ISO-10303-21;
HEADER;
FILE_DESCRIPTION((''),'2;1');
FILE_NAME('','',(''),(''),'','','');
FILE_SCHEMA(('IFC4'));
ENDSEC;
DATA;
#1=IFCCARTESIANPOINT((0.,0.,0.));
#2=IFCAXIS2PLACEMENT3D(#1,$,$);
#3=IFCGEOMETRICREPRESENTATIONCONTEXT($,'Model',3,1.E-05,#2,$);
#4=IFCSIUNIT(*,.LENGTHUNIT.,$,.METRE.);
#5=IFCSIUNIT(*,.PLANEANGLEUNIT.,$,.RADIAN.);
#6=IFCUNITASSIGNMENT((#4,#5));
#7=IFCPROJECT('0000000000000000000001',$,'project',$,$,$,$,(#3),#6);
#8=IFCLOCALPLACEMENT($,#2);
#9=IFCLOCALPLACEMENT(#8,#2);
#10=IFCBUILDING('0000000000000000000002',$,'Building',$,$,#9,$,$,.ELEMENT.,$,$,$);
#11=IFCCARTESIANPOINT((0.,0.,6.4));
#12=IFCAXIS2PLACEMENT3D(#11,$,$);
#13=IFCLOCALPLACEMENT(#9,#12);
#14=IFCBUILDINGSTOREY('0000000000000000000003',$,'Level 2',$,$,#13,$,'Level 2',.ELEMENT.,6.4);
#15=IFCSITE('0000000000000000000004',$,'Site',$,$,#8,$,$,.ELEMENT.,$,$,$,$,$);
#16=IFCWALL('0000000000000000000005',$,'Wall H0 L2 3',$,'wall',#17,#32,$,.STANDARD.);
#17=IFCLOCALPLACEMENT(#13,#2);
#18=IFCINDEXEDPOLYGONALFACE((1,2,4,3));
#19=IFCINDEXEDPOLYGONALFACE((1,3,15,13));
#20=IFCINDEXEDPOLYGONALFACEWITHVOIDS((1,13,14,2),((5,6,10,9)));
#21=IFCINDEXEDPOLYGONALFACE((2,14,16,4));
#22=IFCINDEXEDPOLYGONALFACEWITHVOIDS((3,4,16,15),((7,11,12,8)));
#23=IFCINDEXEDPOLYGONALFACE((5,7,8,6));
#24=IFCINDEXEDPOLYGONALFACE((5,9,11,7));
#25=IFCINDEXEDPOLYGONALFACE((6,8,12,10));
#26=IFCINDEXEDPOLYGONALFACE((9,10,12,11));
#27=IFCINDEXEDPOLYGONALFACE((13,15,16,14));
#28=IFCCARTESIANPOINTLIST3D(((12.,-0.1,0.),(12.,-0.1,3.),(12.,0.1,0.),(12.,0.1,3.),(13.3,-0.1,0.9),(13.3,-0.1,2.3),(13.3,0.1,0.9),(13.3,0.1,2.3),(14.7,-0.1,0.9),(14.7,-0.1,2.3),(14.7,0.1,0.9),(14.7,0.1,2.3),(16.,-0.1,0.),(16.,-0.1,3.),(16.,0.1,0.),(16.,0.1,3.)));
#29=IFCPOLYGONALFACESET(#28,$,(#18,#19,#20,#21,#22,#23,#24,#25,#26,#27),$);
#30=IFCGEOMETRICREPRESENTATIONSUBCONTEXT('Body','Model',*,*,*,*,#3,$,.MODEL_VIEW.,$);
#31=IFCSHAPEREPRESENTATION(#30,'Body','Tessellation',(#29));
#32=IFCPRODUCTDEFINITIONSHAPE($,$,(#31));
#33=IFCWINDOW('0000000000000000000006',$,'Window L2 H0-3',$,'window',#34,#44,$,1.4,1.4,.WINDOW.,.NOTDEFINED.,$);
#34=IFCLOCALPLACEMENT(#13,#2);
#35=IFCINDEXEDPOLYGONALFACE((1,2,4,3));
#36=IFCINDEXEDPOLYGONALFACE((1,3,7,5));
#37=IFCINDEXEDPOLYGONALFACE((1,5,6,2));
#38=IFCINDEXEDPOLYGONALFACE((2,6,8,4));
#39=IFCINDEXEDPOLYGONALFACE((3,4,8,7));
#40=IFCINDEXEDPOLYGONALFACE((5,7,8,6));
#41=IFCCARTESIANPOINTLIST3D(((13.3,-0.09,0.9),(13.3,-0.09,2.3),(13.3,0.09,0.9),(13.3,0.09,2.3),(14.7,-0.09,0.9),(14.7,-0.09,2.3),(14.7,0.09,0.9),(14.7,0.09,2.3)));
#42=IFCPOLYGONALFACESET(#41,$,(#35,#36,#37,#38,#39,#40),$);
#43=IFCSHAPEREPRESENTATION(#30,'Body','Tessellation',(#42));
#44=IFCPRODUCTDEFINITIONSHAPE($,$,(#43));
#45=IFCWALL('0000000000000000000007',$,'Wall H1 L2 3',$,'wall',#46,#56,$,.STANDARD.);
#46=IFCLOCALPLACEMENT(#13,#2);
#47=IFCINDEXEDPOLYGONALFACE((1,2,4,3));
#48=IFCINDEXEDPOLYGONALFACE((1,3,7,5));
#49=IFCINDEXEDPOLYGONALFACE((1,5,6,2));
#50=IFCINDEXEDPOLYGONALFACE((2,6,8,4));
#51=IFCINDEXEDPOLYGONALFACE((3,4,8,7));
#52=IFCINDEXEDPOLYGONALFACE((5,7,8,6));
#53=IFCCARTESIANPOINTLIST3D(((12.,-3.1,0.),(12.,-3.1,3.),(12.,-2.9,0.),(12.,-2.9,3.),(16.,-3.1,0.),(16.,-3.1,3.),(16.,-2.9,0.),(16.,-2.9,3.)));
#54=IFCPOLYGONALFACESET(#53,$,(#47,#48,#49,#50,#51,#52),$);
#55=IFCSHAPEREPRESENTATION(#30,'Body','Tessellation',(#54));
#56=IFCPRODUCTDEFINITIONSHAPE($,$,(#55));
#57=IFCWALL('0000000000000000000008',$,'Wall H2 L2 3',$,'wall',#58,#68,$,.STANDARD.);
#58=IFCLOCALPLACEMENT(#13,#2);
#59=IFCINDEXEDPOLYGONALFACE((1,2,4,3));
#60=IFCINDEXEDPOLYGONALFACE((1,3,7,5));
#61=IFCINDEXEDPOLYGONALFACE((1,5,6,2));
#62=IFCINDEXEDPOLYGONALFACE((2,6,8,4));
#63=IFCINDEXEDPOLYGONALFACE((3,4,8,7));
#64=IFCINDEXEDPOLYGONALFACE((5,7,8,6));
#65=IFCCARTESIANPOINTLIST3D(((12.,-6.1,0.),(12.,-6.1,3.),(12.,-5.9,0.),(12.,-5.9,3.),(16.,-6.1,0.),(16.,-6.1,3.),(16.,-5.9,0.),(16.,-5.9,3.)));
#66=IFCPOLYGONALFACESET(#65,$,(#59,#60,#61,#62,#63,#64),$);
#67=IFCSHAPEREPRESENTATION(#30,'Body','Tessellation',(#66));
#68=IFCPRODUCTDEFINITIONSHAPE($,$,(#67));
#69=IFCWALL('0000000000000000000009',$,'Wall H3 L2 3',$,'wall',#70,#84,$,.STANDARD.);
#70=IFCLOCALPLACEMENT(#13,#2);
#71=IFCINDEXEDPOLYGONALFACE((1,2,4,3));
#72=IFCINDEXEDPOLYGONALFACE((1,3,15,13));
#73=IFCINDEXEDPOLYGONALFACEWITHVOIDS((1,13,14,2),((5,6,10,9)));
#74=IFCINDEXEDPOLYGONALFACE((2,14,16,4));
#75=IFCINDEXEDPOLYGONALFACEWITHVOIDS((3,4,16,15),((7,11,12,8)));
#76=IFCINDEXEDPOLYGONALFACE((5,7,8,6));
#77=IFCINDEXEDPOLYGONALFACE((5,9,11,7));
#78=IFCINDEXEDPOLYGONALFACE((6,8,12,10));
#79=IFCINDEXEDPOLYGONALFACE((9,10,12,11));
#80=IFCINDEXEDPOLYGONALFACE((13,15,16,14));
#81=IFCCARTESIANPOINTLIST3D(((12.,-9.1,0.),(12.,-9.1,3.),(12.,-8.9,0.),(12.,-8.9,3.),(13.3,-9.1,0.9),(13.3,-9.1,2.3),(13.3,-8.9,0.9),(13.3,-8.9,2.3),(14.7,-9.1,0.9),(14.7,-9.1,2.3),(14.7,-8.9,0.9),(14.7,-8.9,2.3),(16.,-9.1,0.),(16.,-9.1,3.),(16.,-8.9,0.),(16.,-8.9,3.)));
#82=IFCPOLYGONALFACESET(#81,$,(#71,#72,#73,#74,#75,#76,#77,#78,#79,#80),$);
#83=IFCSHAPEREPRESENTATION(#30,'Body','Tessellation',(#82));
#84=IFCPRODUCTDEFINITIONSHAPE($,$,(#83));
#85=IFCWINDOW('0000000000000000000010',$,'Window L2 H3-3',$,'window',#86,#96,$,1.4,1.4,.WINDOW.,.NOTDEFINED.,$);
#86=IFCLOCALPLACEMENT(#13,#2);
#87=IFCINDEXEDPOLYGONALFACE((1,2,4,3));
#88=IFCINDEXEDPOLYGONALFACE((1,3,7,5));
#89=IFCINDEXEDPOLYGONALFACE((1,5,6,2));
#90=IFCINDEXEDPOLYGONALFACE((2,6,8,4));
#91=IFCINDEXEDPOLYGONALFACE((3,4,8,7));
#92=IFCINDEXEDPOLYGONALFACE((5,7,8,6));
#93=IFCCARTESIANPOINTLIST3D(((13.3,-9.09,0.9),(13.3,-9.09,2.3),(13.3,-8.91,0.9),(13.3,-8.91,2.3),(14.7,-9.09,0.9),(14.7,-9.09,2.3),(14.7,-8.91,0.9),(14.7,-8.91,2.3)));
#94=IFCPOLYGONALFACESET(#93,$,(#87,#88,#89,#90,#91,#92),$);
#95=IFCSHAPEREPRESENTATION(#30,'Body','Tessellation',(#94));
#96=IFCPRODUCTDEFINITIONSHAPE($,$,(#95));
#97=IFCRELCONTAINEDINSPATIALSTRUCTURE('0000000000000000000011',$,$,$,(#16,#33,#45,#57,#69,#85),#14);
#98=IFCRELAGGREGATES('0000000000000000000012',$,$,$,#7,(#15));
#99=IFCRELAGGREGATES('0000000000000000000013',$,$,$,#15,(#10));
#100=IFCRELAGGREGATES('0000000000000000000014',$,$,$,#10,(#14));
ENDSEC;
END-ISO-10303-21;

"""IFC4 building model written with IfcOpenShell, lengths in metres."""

from ifc_helpers import new_model, si_unit, frame, frame_2d, origin, origin_2d, place, context, subcontext, project, spatial, rectangle, extrude, element, fill, save


model = new_model("IFC4")

# Units and contexts
model_context = context("Model", 3, precision=1e-05, world=origin())
body_context = subcontext(model_context, "Body", "Model", "MODEL_VIEW")
ifc_project = project(units=[si_unit("LENGTHUNIT", "METRE"), si_unit("PLANEANGLEUNIT", "RADIAN")], contexts=[model_context])

# Site, building, storey
site_placement = place(None, origin())
site = spatial("IfcSite", under=ifc_project, at=site_placement, Name="Site", CompositionType="ELEMENT")
building_placement = place(site_placement, origin())
building = spatial("IfcBuilding", under=site, at=building_placement, Name="Building", CompositionType="ELEMENT")
storey_placement = place(building_placement, frame((0.0, 0.0, 6.4)))
storey = spatial("IfcBuildingStorey", under=building, at=storey_placement, Name="Level 2", LongName="Level 2", CompositionType="ELEMENT", Elevation=6.4)

# Wall, opening, window
wall_1_placement = place(storey_placement, frame((12.0, 0.0, 0.0), z_axis=(0.0, 0.0, 1.0), x_axis=(1.0, 0.0, 0.0)))
wall_1 = element("IfcWall", 1, at=wall_1_placement, inside=storey, Name="Wall H0 L2 3", ObjectType="wall", PredefinedType="STANDARD", context=body_context, shape_type="SweptSolid", body=[
    extrude(rectangle(XDim=4.0, YDim=0.2, at=frame_2d((2.0, 0.0))), origin(), (0.0, 0.0, 1.0), 3.0),
])
opening_1_placement = place(storey_placement, frame((14.0, 0.0, 0.9), z_axis=(0.0, 0.0, 1.0), x_axis=(1.0, 0.0, 0.0)))
opening_1 = element("IfcOpeningElement", 2, at=opening_1_placement, cuts=wall_1, ObjectType="Opening", PredefinedType="OPENING", context=body_context, shape_type="SweptSolid", body=[
    extrude(rectangle(XDim=1.4, YDim=0.22, at=origin_2d()), origin(), (0.0, 0.0, 1.0), 1.4),
])
window_1_placement = place(storey_placement, frame((14.0, 0.0, 0.9), z_axis=(0.0, 0.0, 1.0), x_axis=(1.0, 0.0, 0.0)))
window_1 = element("IfcWindow", 3, at=window_1_placement, inside=storey, Name="Window L2 H0-3", ObjectType="window", OverallHeight=1.4, OverallWidth=1.4, PartitioningType="NOTDEFINED", PredefinedType="WINDOW", context=body_context, shape_type="SweptSolid", body=[
    extrude(rectangle(XDim=1.4, YDim=0.18, at=origin_2d()), origin(), (0.0, 0.0, 1.0), 1.4),
])
fill(opening_1, window_1)

# Walls
for number, where, z_axis, x_axis, name in (
    (4, (12.0, -3.0, 0.0), (0.0, 0.0, 1.0), (1.0, 0.0, 0.0), "Wall H1 L2 3"),
    (5, (12.0, -6.0, 0.0), (0.0, 0.0, 1.0), (1.0, 0.0, 0.0), "Wall H2 L2 3"),
):
    element("IfcWall", number, at=place(storey_placement, frame(where, z_axis=z_axis, x_axis=x_axis)), inside=storey, Name=name, ObjectType="wall", PredefinedType="STANDARD", context=body_context, shape_type="SweptSolid", body=[
        extrude(rectangle(XDim=4.0, YDim=0.2, at=frame_2d((2.0, 0.0))), origin(), (0.0, 0.0, 1.0), 3.0),
    ])

# Wall, opening, window
wall_2_placement = place(storey_placement, frame((12.0, -9.0, 0.0), z_axis=(0.0, 0.0, 1.0), x_axis=(1.0, 0.0, 0.0)))
wall_2 = element("IfcWall", 6, at=wall_2_placement, inside=storey, Name="Wall H3 L2 3", ObjectType="wall", PredefinedType="STANDARD", context=body_context, shape_type="SweptSolid", body=[
    extrude(rectangle(XDim=4.0, YDim=0.2, at=frame_2d((2.0, 0.0))), origin(), (0.0, 0.0, 1.0), 3.0),
])
opening_2_placement = place(storey_placement, frame((14.0, -9.0, 0.9), z_axis=(0.0, 0.0, 1.0), x_axis=(1.0, 0.0, 0.0)))
opening_2 = element("IfcOpeningElement", 7, at=opening_2_placement, cuts=wall_2, ObjectType="Opening", PredefinedType="OPENING", context=body_context, shape_type="SweptSolid", body=[
    extrude(rectangle(XDim=1.4, YDim=0.22, at=origin_2d()), origin(), (0.0, 0.0, 1.0), 1.4),
])
window_2_placement = place(storey_placement, frame((14.0, -9.0, 0.9), z_axis=(0.0, 0.0, 1.0), x_axis=(1.0, 0.0, 0.0)))
window_2 = element("IfcWindow", 8, at=window_2_placement, inside=storey, Name="Window L2 H3-3", ObjectType="window", OverallHeight=1.4, OverallWidth=1.4, PartitioningType="NOTDEFINED", PredefinedType="WINDOW", context=body_context, shape_type="SweptSolid", body=[
    extrude(rectangle(XDim=1.4, YDim=0.18, at=origin_2d()), origin(), (0.0, 0.0, 1.0), 1.4),
])
fill(opening_2, window_2)

save(model, "model.ifc")
